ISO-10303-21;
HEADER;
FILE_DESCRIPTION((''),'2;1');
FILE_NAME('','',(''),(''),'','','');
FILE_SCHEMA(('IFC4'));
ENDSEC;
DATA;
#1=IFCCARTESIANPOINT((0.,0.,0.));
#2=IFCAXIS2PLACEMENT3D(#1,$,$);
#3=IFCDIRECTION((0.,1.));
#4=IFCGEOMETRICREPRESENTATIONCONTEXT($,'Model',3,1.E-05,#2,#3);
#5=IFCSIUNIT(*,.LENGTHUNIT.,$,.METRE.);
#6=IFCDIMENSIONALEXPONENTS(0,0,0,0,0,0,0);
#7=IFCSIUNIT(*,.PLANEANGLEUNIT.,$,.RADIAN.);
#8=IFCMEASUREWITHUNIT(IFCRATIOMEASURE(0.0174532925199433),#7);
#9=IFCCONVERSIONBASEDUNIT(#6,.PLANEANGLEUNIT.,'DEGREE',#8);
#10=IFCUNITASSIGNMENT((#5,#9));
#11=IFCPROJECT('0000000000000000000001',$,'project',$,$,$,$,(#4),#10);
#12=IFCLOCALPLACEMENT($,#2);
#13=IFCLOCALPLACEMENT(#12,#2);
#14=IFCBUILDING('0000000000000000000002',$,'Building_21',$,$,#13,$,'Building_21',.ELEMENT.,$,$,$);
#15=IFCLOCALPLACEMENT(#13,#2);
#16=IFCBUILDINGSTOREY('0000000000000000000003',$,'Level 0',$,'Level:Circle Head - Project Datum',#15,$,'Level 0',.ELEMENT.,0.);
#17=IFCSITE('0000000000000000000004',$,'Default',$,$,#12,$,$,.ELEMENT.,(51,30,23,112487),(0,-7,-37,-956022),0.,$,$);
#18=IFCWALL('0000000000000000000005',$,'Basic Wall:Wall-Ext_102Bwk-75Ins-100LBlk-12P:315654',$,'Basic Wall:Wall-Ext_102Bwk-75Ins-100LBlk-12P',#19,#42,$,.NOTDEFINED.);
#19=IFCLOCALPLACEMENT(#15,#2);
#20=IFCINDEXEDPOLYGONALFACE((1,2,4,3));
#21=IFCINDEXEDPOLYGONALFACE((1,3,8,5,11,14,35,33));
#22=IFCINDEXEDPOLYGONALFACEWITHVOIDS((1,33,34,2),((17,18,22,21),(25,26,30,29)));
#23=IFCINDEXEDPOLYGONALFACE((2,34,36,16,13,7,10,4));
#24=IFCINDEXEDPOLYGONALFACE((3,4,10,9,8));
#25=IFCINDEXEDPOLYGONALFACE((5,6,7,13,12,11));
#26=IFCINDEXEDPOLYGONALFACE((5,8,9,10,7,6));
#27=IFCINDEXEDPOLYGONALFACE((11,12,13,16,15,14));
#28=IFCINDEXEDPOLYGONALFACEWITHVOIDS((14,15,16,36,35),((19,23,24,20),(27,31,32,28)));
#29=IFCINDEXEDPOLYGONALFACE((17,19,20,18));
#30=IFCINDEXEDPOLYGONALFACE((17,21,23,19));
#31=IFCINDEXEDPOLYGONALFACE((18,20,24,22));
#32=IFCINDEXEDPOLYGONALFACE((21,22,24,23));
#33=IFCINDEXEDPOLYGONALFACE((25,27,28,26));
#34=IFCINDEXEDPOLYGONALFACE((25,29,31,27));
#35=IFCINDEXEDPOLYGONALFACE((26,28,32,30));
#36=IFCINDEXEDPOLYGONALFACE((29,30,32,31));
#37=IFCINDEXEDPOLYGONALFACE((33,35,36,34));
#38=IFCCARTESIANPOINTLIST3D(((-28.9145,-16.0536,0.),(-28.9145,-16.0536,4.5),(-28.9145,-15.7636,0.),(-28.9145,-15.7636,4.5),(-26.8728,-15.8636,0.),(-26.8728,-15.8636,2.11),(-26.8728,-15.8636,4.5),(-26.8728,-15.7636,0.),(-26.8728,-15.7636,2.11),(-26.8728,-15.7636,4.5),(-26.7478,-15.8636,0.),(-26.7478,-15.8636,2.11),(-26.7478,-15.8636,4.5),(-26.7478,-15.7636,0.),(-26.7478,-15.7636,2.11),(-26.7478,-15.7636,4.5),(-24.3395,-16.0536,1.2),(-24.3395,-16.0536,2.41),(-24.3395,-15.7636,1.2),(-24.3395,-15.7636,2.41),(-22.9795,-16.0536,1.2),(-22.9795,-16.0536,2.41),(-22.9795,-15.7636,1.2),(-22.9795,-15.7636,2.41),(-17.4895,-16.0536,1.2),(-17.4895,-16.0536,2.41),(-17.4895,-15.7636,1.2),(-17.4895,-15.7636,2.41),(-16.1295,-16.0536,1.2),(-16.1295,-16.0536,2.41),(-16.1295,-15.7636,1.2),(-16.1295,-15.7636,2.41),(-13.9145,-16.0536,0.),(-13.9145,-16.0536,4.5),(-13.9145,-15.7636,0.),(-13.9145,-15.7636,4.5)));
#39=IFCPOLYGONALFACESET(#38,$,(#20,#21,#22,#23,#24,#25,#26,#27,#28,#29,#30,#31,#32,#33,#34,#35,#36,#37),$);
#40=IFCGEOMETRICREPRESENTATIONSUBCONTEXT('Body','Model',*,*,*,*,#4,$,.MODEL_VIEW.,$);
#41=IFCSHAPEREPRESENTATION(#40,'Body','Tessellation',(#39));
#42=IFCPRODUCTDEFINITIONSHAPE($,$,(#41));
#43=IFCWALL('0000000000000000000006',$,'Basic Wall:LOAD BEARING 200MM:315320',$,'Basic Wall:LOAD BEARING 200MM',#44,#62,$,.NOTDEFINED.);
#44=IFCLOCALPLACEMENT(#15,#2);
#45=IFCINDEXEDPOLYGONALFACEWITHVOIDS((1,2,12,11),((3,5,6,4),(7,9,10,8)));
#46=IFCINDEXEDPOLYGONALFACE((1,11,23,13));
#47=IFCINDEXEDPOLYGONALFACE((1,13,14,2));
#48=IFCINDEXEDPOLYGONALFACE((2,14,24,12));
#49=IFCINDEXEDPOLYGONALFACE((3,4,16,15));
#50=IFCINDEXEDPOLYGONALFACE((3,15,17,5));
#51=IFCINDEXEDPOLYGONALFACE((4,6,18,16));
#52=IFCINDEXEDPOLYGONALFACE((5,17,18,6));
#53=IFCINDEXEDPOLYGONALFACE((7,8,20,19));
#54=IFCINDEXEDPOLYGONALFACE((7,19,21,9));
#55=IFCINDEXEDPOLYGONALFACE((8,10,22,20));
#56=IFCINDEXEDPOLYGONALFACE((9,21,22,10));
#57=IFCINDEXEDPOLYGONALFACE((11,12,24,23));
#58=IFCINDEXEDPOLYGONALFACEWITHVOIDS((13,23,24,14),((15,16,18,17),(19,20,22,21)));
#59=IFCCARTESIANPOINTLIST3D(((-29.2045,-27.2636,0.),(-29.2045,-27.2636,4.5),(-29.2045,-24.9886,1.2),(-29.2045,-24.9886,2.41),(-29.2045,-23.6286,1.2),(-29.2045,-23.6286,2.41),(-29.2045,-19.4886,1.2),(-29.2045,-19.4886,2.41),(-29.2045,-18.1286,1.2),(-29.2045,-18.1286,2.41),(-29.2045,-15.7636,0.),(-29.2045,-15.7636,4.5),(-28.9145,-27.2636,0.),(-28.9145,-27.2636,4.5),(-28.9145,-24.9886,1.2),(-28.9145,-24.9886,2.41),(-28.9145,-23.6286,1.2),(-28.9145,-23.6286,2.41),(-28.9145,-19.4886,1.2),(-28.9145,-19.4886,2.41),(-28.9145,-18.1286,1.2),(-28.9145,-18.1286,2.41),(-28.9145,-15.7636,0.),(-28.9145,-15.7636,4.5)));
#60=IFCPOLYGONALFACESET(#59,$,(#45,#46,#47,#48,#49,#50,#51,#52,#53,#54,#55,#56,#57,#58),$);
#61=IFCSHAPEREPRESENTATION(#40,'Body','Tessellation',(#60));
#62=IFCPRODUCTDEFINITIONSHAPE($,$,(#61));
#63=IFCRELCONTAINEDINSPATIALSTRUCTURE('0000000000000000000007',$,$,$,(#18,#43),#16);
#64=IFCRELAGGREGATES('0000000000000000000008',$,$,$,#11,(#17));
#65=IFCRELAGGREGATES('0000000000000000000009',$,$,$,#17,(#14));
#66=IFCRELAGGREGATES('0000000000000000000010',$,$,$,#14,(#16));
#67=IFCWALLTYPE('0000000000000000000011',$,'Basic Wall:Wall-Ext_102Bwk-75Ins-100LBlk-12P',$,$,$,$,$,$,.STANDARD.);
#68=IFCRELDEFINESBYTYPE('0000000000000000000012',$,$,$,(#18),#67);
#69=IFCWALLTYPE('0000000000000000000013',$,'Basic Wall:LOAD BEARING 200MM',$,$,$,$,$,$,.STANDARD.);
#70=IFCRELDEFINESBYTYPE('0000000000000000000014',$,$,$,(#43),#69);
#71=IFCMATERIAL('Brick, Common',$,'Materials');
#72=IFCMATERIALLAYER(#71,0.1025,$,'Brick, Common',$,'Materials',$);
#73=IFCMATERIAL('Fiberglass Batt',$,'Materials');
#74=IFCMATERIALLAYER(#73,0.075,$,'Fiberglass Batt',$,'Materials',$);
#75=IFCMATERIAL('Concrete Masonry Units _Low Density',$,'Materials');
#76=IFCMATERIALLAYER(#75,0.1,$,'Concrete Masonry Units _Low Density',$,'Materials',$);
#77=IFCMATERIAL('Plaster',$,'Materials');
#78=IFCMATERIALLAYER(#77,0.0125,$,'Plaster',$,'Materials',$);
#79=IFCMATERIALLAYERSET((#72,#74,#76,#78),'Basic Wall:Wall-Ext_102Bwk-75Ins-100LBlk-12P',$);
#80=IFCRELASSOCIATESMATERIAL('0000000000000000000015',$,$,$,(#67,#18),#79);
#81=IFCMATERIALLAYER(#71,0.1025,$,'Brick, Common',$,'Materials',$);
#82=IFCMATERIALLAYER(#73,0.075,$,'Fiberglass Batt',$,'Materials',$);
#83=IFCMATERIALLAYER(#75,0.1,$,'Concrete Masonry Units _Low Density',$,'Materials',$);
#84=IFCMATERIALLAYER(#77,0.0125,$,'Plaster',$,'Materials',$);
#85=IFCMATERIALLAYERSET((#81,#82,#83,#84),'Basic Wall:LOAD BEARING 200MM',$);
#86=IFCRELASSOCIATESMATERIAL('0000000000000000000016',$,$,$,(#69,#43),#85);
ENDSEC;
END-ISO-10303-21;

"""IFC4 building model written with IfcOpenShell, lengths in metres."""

from ifc_helpers import new_model, entity, si_unit, converted_unit, direction, frame, frame_2d, origin, place, context, subcontext, project, spatial, polyline, rectangle, outline, extrude, material, layer, layer_set, layer_usage, type_object, element, save


model = new_model("IFC4")

# Units and contexts
model_context = context("Model", 3, precision=1e-05, world=origin(), true_north=direction((0.0, 1.0)))
body_context = subcontext(model_context, "Body", "Model", "MODEL_VIEW")
ifc_project = project(units=[si_unit("LENGTHUNIT", "METRE"), converted_unit("PLANEANGLEUNIT", "DEGREE", entity("IfcRatioMeasure", 0.0174532925199433), si_unit("PLANEANGLEUNIT", "RADIAN"), dimensions=[0, 0, 0, 0, 0, 0, 0])], contexts=[model_context])

# Site, building, storey
site_placement = place(None, origin())
site = spatial("IfcSite", under=ifc_project, at=site_placement, Name="Default", CompositionType="ELEMENT", RefLatitude=(51, 30, 23, 112487), RefLongitude=(0, -7, -37, -956022), RefElevation=0.0)
building_placement = place(site_placement, origin())
building = spatial("IfcBuilding", under=site, at=building_placement, Name="Building_21", LongName="Building_21", CompositionType="ELEMENT")
storey_placement = place(building_placement, origin())
storey = spatial("IfcBuildingStorey", under=building, at=storey_placement, Name="Level 0", ObjectType="Level:Circle Head - Project Datum", LongName="Level 0", CompositionType="ELEMENT", Elevation=0.0)

# Shared definitions
ifc_material_1 = material(Name="Brick, Common", Category="Materials")
ifc_layer_1 = layer(ifc_material_1, 0.1025, Name="Brick, Common", Category="Materials")
ifc_material_2 = material(Name="Fiberglass Batt", Category="Materials")
ifc_layer_2 = layer(ifc_material_2, 0.075, Name="Fiberglass Batt", Category="Materials")
ifc_material_3 = material(Name="Concrete Masonry Units _Low Density", Category="Materials")
ifc_layer_3 = layer(ifc_material_3, 0.1, Name="Concrete Masonry Units _Low Density", Category="Materials")
ifc_material_4 = material(Name="Plaster", Category="Materials")
ifc_layer_4 = layer(ifc_material_4, 0.0125, Name="Plaster", Category="Materials")
ifc_layer_set_1 = layer_set([ifc_layer_1, ifc_layer_2, ifc_layer_3, ifc_layer_4], Name="Basic Wall:Wall-Ext_102Bwk-75Ins-100LBlk-12P")
wall_type_1 = type_object("IfcWallType", Name="Basic Wall:Wall-Ext_102Bwk-75Ins-100LBlk-12P", PredefinedType="STANDARD", material=ifc_layer_set_1)

# Walls, openings
ifc_layer_usage_1 = layer_usage(ifc_layer_set_1, "AXIS2", "NEGATIVE", 0.145)
wall_1_placement = place(storey_placement, frame((-28.9145, -15.9086, 0.0)))
wall_1 = element("IfcWall", 1, at=wall_1_placement, inside=storey, type_object=wall_type_1, material=ifc_layer_usage_1, Name="Basic Wall:Wall-Ext_102Bwk-75Ins-100LBlk-12P:315654", ObjectType="Basic Wall:Wall-Ext_102Bwk-75Ins-100LBlk-12P", PredefinedType="NOTDEFINED", context=body_context, shape_type="SweptSolid", body=[
    extrude(outline(polyline([(15.0, -0.145), (15.0, 0.145), (14.71, 0.145), (9.4175, 0.145), (9.2925, 0.145), (7.4175, 0.145), (7.2925, 0.145), (2.1667, 0.145), (2.1667, 0.045), (2.0417, 0.045), (2.0417, 0.145), (0.0, 0.145), (0.0, -0.145), (15.0, -0.145)])), origin(), (0.0, 0.0, 1.0), 4.5),
])
opening_1_placement = place(wall_1_placement, frame((2.0417, 0.045, 0.0)))
element("IfcOpeningElement", 2, at=opening_1_placement, cuts=wall_1, PredefinedType="OPENING", context=body_context, shape_type="SweptSolid", body=[
    extrude(rectangle(XDim=2.11, YDim=0.125, at=frame_2d((0.0, 0.0), x_axis=(0.0, 1.0))), frame((0.0625, 0.0, 1.055), z_axis=(0.0, 1.0, 0.0), x_axis=(-1.0, 0.0, 0.0)), (0.0, 0.0, 1.0), 0.81),
])
opening_2_placement = place(wall_1_placement, frame((5.935, 0.145, 1.2)))
element("IfcOpeningElement", 3, at=opening_2_placement, cuts=wall_1, PredefinedType="OPENING", context=body_context, shape_type="SweptSolid", body=[
    extrude(rectangle(XDim=1.21, YDim=1.36, at=frame_2d((0.605, 0.68), x_axis=(-1.0, 0.0))), frame((0.0, 0.0, 0.0), z_axis=(0.0, -1.0, 0.0), x_axis=(0.0, 0.0, 1.0)), (0.0, 0.0, 1.0), 0.29),
])
opening_3_placement = place(wall_1_placement, frame((12.785, 0.145, 1.2)))
element("IfcOpeningElement", 4, at=opening_3_placement, cuts=wall_1, PredefinedType="OPENING", context=body_context, shape_type="SweptSolid", body=[
    extrude(rectangle(XDim=1.21, YDim=1.36, at=frame_2d((0.605, 0.68), x_axis=(-1.0, 0.0))), frame((0.0, 0.0, 0.0), z_axis=(0.0, -1.0, 0.0), x_axis=(0.0, 0.0, 1.0)), (0.0, 0.0, 1.0), 0.29),
])
ifc_layer_5 = layer(ifc_material_1, 0.1025, Name="Brick, Common", Category="Materials")
ifc_layer_6 = layer(ifc_material_2, 0.075, Name="Fiberglass Batt", Category="Materials")
ifc_layer_7 = layer(ifc_material_3, 0.1, Name="Concrete Masonry Units _Low Density", Category="Materials")
ifc_layer_8 = layer(ifc_material_4, 0.0125, Name="Plaster", Category="Materials")
ifc_layer_set_2 = layer_set([ifc_layer_5, ifc_layer_6, ifc_layer_7, ifc_layer_8], Name="Basic Wall:LOAD BEARING 200MM")
ifc_layer_usage_2 = layer_usage(ifc_layer_set_2, "AXIS2", "NEGATIVE", 0.145)
wall_type_2 = type_object("IfcWallType", Name="Basic Wall:LOAD BEARING 200MM", PredefinedType="STANDARD", material=ifc_layer_set_2)
wall_2_placement = place(storey_placement, frame((-29.0595, -27.2636, 0.0), z_axis=(0.0, 0.0, 1.0), x_axis=(0.0, 1.0, 0.0)))
wall_2 = element("IfcWall", 5, at=wall_2_placement, inside=storey, type_object=wall_type_2, material=ifc_layer_usage_2, Name="Basic Wall:LOAD BEARING 200MM:315320", ObjectType="Basic Wall:LOAD BEARING 200MM", PredefinedType="NOTDEFINED", context=body_context, shape_type="SweptSolid", body=[
    extrude(rectangle(XDim=11.5, YDim=0.29, at=frame_2d((5.75, 0.0), x_axis=(-1.0, 0.0))), origin(), (0.0, 0.0, 1.0), 4.5),
])
opening_4_placement = place(wall_2_placement, frame((3.635, 0.145, 1.2)))
element("IfcOpeningElement", 6, at=opening_4_placement, cuts=wall_2, PredefinedType="OPENING", context=body_context, shape_type="SweptSolid", body=[
    extrude(rectangle(XDim=1.21, YDim=1.36, at=frame_2d((0.605, 0.68), x_axis=(-1.0, 0.0))), frame((0.0, 0.0, 0.0), z_axis=(0.0, -1.0, 0.0), x_axis=(0.0, 0.0, 1.0)), (0.0, 0.0, 1.0), 0.29),
])
opening_5_placement = place(wall_2_placement, frame((9.135, 0.145, 1.2)))
element("IfcOpeningElement", 7, at=opening_5_placement, cuts=wall_2, PredefinedType="OPENING", context=body_context, shape_type="SweptSolid", body=[
    extrude(rectangle(XDim=1.21, YDim=1.36, at=frame_2d((0.605, 0.68), x_axis=(-1.0, 0.0))), frame((0.0, 0.0, 0.0), z_axis=(0.0, -1.0, 0.0), x_axis=(0.0, 0.0, 1.0)), (0.0, 0.0, 1.0), 0.29),
])

save(model, "model.ifc")
